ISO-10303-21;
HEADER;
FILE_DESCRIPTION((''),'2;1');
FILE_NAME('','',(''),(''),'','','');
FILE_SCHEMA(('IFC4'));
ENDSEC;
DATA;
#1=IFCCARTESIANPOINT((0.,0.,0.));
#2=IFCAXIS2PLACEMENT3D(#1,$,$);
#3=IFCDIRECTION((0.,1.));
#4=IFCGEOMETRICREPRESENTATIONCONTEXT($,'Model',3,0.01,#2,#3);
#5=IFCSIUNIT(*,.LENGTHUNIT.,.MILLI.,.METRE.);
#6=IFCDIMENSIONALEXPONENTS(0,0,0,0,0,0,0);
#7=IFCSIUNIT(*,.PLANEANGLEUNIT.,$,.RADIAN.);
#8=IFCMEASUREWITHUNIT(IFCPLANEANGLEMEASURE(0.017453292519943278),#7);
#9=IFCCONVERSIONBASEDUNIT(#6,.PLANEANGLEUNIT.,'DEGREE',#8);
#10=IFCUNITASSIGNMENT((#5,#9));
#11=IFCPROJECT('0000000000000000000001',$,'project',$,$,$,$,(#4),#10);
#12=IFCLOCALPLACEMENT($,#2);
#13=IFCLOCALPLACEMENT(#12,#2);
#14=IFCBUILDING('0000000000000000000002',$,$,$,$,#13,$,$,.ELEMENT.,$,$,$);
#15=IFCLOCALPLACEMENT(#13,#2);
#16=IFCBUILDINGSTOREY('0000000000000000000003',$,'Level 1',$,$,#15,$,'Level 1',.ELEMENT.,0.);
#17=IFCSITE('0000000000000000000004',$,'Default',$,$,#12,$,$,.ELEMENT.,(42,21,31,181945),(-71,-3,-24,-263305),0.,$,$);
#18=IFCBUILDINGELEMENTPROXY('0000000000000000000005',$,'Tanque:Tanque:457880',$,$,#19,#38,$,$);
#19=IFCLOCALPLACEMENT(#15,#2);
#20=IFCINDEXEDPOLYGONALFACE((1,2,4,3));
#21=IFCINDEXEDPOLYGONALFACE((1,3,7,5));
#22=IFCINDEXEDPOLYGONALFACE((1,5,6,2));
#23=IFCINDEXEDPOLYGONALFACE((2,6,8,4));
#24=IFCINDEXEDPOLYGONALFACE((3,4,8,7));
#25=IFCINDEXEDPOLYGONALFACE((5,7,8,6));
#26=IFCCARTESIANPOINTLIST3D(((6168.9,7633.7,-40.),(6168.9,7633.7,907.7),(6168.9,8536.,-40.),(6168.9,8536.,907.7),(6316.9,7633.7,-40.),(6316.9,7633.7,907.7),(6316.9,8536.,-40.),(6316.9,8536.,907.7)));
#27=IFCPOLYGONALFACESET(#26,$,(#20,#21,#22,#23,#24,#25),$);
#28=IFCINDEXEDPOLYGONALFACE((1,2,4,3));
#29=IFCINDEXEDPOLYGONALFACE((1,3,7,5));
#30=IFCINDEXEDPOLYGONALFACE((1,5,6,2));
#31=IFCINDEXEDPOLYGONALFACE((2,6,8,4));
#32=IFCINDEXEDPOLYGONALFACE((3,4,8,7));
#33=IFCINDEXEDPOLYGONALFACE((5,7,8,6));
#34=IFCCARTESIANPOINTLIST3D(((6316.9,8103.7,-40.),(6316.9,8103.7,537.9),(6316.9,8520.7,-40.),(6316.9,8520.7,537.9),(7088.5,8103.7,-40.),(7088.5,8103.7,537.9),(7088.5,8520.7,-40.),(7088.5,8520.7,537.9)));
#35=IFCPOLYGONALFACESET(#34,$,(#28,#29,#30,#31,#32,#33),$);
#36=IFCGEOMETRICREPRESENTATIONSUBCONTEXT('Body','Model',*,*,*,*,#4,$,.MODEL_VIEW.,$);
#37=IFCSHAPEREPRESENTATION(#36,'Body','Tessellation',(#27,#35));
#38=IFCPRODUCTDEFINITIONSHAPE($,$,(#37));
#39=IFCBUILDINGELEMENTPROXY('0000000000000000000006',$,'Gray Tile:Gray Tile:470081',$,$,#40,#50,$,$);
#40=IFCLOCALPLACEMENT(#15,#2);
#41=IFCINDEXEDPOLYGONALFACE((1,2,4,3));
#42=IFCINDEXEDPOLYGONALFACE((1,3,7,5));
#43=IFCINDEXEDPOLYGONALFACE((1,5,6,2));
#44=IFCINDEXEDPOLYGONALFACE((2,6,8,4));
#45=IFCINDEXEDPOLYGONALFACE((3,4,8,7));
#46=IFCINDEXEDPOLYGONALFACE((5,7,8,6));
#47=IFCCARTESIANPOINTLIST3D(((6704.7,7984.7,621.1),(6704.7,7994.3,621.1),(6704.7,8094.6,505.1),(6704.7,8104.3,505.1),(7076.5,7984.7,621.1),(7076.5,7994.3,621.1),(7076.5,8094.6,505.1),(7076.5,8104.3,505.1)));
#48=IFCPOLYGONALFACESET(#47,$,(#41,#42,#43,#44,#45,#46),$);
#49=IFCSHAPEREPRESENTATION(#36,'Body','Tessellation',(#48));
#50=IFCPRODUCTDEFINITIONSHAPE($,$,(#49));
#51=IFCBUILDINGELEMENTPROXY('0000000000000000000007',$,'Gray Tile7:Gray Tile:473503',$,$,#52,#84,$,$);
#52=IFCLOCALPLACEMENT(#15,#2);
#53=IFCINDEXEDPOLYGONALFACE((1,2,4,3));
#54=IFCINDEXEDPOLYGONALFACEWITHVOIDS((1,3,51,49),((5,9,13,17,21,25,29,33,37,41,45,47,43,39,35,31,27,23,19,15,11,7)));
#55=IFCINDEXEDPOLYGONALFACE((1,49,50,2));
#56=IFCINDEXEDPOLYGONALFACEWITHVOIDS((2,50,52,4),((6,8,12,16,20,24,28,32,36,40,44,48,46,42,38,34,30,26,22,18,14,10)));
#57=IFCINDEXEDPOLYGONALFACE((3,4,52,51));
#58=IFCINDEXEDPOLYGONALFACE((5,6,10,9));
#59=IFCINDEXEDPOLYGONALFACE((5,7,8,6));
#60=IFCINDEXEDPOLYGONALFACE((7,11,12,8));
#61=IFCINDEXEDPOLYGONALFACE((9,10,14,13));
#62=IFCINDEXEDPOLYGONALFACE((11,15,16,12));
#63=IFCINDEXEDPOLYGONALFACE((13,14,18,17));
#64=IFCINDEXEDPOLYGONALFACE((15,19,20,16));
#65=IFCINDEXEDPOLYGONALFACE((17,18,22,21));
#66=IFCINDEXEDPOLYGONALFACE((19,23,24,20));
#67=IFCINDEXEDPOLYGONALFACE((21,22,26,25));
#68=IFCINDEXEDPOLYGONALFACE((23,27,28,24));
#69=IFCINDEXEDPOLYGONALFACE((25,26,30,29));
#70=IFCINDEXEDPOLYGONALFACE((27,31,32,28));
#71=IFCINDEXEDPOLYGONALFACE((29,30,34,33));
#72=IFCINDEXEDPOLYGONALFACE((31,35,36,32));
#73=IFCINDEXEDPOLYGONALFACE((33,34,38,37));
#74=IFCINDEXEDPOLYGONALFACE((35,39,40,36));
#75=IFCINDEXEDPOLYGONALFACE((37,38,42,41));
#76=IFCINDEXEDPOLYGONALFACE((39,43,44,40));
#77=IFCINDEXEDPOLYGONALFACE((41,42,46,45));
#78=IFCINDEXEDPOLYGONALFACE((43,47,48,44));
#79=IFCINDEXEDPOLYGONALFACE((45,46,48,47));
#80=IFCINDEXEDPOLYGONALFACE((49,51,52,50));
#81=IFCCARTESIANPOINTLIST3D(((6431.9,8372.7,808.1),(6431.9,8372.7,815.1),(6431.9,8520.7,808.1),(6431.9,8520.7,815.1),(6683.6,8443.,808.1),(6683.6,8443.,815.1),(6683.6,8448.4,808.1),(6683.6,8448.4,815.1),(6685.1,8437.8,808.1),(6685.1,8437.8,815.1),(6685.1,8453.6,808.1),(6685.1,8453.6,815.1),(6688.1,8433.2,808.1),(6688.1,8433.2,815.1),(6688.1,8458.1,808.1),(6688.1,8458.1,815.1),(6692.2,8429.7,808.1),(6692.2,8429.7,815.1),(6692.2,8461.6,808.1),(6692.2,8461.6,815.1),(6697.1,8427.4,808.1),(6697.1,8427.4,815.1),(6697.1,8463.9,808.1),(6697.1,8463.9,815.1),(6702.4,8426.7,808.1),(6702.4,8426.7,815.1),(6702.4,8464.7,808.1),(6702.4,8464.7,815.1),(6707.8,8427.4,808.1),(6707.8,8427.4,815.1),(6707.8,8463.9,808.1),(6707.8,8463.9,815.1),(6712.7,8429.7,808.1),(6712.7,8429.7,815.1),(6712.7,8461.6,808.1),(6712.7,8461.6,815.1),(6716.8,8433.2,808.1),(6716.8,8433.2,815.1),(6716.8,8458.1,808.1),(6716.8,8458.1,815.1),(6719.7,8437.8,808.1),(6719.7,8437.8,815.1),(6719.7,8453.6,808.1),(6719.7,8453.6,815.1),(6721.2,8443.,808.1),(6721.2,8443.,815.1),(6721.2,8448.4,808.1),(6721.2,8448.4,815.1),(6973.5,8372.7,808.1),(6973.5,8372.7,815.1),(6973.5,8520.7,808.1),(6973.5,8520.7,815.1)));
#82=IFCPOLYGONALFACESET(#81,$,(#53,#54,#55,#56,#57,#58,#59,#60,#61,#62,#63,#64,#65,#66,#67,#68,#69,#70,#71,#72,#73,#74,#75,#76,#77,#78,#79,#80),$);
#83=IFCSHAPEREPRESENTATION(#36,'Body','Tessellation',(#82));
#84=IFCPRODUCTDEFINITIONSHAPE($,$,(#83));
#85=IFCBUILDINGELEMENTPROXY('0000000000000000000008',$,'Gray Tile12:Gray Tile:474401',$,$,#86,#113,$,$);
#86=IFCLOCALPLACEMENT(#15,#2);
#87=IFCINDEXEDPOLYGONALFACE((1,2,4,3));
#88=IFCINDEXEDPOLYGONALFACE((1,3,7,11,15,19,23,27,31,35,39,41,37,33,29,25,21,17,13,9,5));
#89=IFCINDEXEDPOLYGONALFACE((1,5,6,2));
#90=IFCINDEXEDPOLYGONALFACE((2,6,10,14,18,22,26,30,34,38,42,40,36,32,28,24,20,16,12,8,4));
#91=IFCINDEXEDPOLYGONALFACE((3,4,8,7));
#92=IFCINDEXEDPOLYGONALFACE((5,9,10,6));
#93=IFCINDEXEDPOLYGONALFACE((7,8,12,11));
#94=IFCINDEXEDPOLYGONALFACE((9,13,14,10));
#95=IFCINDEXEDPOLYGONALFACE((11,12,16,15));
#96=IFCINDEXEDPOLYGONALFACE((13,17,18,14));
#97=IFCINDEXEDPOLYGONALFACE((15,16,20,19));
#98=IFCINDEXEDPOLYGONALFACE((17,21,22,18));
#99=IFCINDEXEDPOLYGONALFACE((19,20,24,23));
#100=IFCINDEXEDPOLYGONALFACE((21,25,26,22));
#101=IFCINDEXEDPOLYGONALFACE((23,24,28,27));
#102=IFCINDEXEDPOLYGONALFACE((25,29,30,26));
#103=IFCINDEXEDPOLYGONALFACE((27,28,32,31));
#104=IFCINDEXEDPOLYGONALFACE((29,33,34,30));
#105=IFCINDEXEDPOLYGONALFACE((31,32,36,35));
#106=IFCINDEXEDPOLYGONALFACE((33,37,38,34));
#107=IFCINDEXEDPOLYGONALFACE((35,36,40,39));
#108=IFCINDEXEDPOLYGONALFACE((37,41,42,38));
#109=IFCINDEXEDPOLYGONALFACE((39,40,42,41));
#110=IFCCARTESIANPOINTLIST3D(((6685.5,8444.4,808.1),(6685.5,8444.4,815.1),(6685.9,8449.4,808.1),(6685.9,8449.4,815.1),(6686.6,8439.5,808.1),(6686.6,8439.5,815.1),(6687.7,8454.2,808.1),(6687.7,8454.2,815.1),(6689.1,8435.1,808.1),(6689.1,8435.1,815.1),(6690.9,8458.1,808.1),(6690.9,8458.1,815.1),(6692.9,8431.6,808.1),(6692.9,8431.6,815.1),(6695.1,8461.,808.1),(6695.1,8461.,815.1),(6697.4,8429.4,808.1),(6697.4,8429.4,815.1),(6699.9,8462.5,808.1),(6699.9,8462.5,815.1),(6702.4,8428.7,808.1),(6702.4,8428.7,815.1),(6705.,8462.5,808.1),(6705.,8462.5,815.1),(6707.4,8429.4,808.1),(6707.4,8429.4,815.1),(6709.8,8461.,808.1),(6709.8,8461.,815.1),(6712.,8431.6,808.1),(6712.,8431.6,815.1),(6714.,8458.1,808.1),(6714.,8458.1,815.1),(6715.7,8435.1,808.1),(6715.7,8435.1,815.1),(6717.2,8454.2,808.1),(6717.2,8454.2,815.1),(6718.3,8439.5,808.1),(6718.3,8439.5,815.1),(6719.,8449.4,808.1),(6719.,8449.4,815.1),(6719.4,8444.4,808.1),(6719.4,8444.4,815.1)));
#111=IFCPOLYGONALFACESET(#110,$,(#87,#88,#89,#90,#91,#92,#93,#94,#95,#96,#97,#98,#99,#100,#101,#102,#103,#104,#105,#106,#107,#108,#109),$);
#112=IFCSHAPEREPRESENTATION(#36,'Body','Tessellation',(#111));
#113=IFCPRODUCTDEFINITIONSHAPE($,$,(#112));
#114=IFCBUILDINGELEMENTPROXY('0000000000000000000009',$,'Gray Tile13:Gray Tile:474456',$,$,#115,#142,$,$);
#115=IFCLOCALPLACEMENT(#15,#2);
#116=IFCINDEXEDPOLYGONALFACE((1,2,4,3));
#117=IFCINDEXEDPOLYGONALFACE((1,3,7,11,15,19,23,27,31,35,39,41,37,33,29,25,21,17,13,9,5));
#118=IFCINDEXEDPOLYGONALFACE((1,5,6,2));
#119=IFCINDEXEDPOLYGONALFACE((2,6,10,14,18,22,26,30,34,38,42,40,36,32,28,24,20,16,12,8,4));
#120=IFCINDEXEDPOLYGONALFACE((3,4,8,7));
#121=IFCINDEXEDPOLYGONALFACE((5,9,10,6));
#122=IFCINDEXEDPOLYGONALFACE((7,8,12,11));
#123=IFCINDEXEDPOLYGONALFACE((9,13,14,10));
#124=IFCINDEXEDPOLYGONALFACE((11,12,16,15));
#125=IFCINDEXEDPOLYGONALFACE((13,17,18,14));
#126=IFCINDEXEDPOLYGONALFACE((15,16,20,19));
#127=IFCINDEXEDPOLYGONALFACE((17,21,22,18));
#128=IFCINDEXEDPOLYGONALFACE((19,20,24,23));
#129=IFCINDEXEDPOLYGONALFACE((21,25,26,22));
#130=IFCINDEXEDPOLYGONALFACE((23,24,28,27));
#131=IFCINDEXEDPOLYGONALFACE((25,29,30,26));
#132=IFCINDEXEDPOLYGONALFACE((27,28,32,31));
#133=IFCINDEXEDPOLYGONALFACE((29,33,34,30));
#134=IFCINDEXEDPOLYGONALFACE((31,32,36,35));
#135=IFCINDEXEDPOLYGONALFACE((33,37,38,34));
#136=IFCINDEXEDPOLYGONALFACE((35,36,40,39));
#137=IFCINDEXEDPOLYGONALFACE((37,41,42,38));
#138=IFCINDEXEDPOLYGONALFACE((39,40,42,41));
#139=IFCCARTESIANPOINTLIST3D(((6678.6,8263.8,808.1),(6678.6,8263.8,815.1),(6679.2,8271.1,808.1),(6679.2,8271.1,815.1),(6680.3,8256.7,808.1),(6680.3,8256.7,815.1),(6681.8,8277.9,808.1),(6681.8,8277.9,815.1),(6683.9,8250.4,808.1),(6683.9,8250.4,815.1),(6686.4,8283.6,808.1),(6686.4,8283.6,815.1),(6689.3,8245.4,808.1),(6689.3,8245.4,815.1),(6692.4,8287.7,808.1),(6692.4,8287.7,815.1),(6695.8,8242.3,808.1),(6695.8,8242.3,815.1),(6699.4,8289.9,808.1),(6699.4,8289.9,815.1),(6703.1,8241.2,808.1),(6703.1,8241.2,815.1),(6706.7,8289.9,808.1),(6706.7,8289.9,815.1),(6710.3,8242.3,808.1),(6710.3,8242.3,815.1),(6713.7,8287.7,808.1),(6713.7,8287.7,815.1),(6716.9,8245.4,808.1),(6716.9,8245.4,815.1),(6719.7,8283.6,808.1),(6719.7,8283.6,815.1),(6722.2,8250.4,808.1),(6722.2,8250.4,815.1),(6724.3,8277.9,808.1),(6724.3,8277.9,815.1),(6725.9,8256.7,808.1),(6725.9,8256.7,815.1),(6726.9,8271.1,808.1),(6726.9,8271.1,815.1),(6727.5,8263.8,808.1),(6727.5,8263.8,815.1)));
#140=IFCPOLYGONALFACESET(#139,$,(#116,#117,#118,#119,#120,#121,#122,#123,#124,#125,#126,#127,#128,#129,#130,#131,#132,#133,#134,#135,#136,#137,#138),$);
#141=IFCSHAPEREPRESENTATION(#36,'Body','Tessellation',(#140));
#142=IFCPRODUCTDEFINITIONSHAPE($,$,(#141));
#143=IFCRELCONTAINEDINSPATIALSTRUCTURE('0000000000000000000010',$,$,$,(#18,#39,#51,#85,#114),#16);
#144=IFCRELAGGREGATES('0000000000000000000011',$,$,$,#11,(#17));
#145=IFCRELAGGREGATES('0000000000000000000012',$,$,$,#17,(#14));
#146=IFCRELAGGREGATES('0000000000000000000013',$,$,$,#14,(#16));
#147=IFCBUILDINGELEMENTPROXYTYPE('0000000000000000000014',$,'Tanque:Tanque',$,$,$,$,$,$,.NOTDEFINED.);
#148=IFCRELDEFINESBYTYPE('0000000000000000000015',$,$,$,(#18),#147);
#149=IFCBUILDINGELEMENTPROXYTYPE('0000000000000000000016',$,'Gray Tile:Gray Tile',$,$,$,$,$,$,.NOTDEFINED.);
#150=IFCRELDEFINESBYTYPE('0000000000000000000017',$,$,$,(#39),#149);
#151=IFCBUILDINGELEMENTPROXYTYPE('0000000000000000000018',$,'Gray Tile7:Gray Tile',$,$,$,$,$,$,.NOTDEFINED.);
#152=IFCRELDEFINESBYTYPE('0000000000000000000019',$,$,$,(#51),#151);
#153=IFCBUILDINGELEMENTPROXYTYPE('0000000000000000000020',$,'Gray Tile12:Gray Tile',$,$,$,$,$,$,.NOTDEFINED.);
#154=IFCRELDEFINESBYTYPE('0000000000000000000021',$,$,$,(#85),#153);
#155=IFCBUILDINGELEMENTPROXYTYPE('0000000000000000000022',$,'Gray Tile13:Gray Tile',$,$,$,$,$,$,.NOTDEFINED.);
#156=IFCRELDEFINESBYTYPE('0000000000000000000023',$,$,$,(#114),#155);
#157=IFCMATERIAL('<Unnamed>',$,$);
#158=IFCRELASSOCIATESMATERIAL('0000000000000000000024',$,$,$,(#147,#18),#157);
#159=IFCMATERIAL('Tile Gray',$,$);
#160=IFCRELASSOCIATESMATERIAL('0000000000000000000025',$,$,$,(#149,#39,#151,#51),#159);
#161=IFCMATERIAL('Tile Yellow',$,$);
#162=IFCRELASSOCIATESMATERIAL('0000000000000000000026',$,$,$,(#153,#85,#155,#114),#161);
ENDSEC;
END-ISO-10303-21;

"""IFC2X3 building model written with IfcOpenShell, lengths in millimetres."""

from ifc_helpers import new_model, entity, si_unit, converted_unit, direction, frame, frame_2d, origin, origin_2d_with_axis, place, context, subcontext, project, spatial, polyline, circle_curve, parameter, trimmed, segment, composite_curve, rectangle, circle, outline, extrude, source, transform, mapped, material, type_object, type_shapes, element, save


model = new_model("IFC2X3")

# Units and contexts
model_context = context("Model", 3, precision=0.01, world=origin(), true_north=direction((0.0, 1.0)))
body_context = subcontext(model_context, "Body", "Model", "MODEL_VIEW")
ifc_project = project(units=[si_unit("LENGTHUNIT", "METRE", prefix="MILLI"), converted_unit("PLANEANGLEUNIT", "DEGREE", entity("IfcPlaneAngleMeasure", 0.017453292519943278), si_unit("PLANEANGLEUNIT", "RADIAN"), dimensions=[0, 0, 0, 0, 0, 0, 0])], contexts=[model_context])

# Site, building, storey
site_placement = place(None, origin())
site = spatial("IfcSite", under=ifc_project, at=site_placement, Name="Default", CompositionType="ELEMENT", RefLatitude=(42, 21, 31, 181945), RefLongitude=(-71, -3, -24, -263305), RefElevation=0.0)
building_placement = place(site_placement, origin())
building = spatial("IfcBuilding", under=site, at=building_placement, CompositionType="ELEMENT")
storey_placement = place(building_placement, origin())
storey = spatial("IfcBuildingStorey", under=building, at=storey_placement, Name="Level 1", LongName="Level 1", CompositionType="ELEMENT", Elevation=0.0)

# Building element proxies
ifc_material_1 = material(Name="<Unnamed>")
building_element_proxy_type_1 = type_object("IfcBuildingElementProxyType", Name="Tanque:Tanque", PredefinedType="NOTDEFINED", material=ifc_material_1)
shared_shape_1 = source(origin(), body_context, "Body", "SweptSolid", [
    extrude(rectangle(XDim=902.4, YDim=148.0, at=frame_2d((0.0, 0.0), x_axis=(1.0, 0.0))), frame((6242.9, 8084.8, -40.0), z_axis=(0.0, 0.0, 1.0), x_axis=(0.0, -1.0, 0.0)), (0.0, 0.0, 1.0), 947.7),
    extrude(rectangle(XDim=417.0, YDim=771.6, at=frame_2d((0.0, 0.0), x_axis=(1.0, 0.0))), frame((6702.7, 8312.2, -40.0), z_axis=(0.0, 0.0, 1.0), x_axis=(0.0, -1.0, 0.0)), (0.0, 0.0, 1.0), 577.9),
])
type_shapes(building_element_proxy_type_1, [shared_shape_1])
proxy_1_placement = place(storey_placement, origin())
element("IfcBuildingElementProxy", 1, at=proxy_1_placement, inside=storey, type_object=building_element_proxy_type_1, material=ifc_material_1, Name="Tanque:Tanque:457880", context=body_context, shape_type="MappedRepresentation", body=[
    mapped(shared_shape_1, transform((0.0, 0.0, 0.0), scale=1.0)),
])
ifc_material_2 = material(Name="Tile Gray")
building_element_proxy_type_2 = type_object("IfcBuildingElementProxyType", Name="Gray Tile:Gray Tile", PredefinedType="NOTDEFINED", material=ifc_material_2)
shared_shape_2 = source(origin(), body_context, "Body", "SweptSolid", [
    extrude(outline(polyline([(-83.2, -3.5), (76.6, -3.5), (83.2, 3.5), (-76.6, 3.5), (-83.2, -3.5)])), frame((6704.7, 8044.5, 550.1), z_axis=(1.0, 0.0, 0.0), x_axis=(0.0, -0.688092, 0.725624)), (0.0, 0.0, 1.0), 371.8),
])
type_shapes(building_element_proxy_type_2, [shared_shape_2])
proxy_2_placement = place(storey_placement, frame((0.0, 0.0, 13.0)))
element("IfcBuildingElementProxy", 2, at=proxy_2_placement, inside=storey, type_object=building_element_proxy_type_2, material=ifc_material_2, Name="Gray Tile:Gray Tile:470081", context=body_context, shape_type="MappedRepresentation", body=[
    mapped(shared_shape_2, transform((0.0, 0.0, 0.0), scale=1.0)),
])
building_element_proxy_type_3 = type_object("IfcBuildingElementProxyType", Name="Gray Tile7:Gray Tile", PredefinedType="NOTDEFINED", material=ifc_material_2)
shared_shape_3 = source(origin(), body_context, "Body", "SweptSolid", [
    extrude(outline(polyline([(-74.0, -270.8), (74.0, -270.8), (74.0, 270.8), (-74.0, 270.8), (-74.0, -270.8)]), holes=[composite_curve([segment(trimmed(circle_curve(frame_2d((-1.0, 0.3), x_axis=(-1.0, 0.0)), 19.0), [parameter(360.0)], [parameter(180.0)], True, "PARAMETER"), False, "CONTINUOUS"), segment(trimmed(circle_curve(frame_2d((-1.0, 0.3), x_axis=(-1.0, 0.0)), 19.0), [parameter(180.0)], [parameter(360.0)], True, "PARAMETER"), False, "CONTINUOUS")], self_intersect=False)]), frame((6702.7, 8446.7, 808.1), z_axis=(0.0, 0.0, 1.0), x_axis=(0.0, 1.0, 0.0)), (0.0, 0.0, 1.0), 7.0),
])
type_shapes(building_element_proxy_type_3, [shared_shape_3])
proxy_3_placement = place(storey_placement, origin())
element("IfcBuildingElementProxy", 3, at=proxy_3_placement, inside=storey, type_object=building_element_proxy_type_3, material=ifc_material_2, Name="Gray Tile7:Gray Tile:473503", context=body_context, shape_type="MappedRepresentation", body=[
    mapped(shared_shape_3, transform((0.0, 0.0, 0.0), scale=1.0)),
])
ifc_material_3 = material(Name="Tile Yellow")
building_element_proxy_type_4 = type_object("IfcBuildingElementProxyType", Name="Gray Tile12:Gray Tile", PredefinedType="NOTDEFINED", material=ifc_material_3)
shared_shape_4 = source(origin(), body_context, "Body", "SweptSolid", [
    extrude(circle(Radius=17.0, at=origin_2d_with_axis()), frame((6702.4, 8445.7, 808.1), z_axis=(0.0, 0.0, 1.0), x_axis=(0.0, -1.0, 0.0)), (0.0, 0.0, 1.0), 7.0),
])
type_shapes(building_element_proxy_type_4, [shared_shape_4])
proxy_4_placement = place(storey_placement, origin())
element("IfcBuildingElementProxy", 4, at=proxy_4_placement, inside=storey, type_object=building_element_proxy_type_4, material=ifc_material_3, Name="Gray Tile12:Gray Tile:474401", context=body_context, shape_type="MappedRepresentation", body=[
    mapped(shared_shape_4, transform((0.0, 0.0, 0.0), scale=1.0)),
])
building_element_proxy_type_5 = type_object("IfcBuildingElementProxyType", Name="Gray Tile13:Gray Tile", PredefinedType="NOTDEFINED", material=ifc_material_3)
shared_shape_5 = source(origin(), body_context, "Body", "SweptSolid", [
    extrude(circle(Radius=24.5, at=origin_2d_with_axis()), frame((6703.1, 8265.7, 808.1), z_axis=(0.0, 0.0, 1.0), x_axis=(0.0, -1.0, 0.0)), (0.0, 0.0, 1.0), 7.0),
])
type_shapes(building_element_proxy_type_5, [shared_shape_5])
proxy_5_placement = place(storey_placement, origin())
element("IfcBuildingElementProxy", 5, at=proxy_5_placement, inside=storey, type_object=building_element_proxy_type_5, material=ifc_material_3, Name="Gray Tile13:Gray Tile:474456", context=body_context, shape_type="MappedRepresentation", body=[
    mapped(shared_shape_5, transform((0.0, 0.0, 0.0), scale=1.0)),
])

save(model, "model.ifc")
